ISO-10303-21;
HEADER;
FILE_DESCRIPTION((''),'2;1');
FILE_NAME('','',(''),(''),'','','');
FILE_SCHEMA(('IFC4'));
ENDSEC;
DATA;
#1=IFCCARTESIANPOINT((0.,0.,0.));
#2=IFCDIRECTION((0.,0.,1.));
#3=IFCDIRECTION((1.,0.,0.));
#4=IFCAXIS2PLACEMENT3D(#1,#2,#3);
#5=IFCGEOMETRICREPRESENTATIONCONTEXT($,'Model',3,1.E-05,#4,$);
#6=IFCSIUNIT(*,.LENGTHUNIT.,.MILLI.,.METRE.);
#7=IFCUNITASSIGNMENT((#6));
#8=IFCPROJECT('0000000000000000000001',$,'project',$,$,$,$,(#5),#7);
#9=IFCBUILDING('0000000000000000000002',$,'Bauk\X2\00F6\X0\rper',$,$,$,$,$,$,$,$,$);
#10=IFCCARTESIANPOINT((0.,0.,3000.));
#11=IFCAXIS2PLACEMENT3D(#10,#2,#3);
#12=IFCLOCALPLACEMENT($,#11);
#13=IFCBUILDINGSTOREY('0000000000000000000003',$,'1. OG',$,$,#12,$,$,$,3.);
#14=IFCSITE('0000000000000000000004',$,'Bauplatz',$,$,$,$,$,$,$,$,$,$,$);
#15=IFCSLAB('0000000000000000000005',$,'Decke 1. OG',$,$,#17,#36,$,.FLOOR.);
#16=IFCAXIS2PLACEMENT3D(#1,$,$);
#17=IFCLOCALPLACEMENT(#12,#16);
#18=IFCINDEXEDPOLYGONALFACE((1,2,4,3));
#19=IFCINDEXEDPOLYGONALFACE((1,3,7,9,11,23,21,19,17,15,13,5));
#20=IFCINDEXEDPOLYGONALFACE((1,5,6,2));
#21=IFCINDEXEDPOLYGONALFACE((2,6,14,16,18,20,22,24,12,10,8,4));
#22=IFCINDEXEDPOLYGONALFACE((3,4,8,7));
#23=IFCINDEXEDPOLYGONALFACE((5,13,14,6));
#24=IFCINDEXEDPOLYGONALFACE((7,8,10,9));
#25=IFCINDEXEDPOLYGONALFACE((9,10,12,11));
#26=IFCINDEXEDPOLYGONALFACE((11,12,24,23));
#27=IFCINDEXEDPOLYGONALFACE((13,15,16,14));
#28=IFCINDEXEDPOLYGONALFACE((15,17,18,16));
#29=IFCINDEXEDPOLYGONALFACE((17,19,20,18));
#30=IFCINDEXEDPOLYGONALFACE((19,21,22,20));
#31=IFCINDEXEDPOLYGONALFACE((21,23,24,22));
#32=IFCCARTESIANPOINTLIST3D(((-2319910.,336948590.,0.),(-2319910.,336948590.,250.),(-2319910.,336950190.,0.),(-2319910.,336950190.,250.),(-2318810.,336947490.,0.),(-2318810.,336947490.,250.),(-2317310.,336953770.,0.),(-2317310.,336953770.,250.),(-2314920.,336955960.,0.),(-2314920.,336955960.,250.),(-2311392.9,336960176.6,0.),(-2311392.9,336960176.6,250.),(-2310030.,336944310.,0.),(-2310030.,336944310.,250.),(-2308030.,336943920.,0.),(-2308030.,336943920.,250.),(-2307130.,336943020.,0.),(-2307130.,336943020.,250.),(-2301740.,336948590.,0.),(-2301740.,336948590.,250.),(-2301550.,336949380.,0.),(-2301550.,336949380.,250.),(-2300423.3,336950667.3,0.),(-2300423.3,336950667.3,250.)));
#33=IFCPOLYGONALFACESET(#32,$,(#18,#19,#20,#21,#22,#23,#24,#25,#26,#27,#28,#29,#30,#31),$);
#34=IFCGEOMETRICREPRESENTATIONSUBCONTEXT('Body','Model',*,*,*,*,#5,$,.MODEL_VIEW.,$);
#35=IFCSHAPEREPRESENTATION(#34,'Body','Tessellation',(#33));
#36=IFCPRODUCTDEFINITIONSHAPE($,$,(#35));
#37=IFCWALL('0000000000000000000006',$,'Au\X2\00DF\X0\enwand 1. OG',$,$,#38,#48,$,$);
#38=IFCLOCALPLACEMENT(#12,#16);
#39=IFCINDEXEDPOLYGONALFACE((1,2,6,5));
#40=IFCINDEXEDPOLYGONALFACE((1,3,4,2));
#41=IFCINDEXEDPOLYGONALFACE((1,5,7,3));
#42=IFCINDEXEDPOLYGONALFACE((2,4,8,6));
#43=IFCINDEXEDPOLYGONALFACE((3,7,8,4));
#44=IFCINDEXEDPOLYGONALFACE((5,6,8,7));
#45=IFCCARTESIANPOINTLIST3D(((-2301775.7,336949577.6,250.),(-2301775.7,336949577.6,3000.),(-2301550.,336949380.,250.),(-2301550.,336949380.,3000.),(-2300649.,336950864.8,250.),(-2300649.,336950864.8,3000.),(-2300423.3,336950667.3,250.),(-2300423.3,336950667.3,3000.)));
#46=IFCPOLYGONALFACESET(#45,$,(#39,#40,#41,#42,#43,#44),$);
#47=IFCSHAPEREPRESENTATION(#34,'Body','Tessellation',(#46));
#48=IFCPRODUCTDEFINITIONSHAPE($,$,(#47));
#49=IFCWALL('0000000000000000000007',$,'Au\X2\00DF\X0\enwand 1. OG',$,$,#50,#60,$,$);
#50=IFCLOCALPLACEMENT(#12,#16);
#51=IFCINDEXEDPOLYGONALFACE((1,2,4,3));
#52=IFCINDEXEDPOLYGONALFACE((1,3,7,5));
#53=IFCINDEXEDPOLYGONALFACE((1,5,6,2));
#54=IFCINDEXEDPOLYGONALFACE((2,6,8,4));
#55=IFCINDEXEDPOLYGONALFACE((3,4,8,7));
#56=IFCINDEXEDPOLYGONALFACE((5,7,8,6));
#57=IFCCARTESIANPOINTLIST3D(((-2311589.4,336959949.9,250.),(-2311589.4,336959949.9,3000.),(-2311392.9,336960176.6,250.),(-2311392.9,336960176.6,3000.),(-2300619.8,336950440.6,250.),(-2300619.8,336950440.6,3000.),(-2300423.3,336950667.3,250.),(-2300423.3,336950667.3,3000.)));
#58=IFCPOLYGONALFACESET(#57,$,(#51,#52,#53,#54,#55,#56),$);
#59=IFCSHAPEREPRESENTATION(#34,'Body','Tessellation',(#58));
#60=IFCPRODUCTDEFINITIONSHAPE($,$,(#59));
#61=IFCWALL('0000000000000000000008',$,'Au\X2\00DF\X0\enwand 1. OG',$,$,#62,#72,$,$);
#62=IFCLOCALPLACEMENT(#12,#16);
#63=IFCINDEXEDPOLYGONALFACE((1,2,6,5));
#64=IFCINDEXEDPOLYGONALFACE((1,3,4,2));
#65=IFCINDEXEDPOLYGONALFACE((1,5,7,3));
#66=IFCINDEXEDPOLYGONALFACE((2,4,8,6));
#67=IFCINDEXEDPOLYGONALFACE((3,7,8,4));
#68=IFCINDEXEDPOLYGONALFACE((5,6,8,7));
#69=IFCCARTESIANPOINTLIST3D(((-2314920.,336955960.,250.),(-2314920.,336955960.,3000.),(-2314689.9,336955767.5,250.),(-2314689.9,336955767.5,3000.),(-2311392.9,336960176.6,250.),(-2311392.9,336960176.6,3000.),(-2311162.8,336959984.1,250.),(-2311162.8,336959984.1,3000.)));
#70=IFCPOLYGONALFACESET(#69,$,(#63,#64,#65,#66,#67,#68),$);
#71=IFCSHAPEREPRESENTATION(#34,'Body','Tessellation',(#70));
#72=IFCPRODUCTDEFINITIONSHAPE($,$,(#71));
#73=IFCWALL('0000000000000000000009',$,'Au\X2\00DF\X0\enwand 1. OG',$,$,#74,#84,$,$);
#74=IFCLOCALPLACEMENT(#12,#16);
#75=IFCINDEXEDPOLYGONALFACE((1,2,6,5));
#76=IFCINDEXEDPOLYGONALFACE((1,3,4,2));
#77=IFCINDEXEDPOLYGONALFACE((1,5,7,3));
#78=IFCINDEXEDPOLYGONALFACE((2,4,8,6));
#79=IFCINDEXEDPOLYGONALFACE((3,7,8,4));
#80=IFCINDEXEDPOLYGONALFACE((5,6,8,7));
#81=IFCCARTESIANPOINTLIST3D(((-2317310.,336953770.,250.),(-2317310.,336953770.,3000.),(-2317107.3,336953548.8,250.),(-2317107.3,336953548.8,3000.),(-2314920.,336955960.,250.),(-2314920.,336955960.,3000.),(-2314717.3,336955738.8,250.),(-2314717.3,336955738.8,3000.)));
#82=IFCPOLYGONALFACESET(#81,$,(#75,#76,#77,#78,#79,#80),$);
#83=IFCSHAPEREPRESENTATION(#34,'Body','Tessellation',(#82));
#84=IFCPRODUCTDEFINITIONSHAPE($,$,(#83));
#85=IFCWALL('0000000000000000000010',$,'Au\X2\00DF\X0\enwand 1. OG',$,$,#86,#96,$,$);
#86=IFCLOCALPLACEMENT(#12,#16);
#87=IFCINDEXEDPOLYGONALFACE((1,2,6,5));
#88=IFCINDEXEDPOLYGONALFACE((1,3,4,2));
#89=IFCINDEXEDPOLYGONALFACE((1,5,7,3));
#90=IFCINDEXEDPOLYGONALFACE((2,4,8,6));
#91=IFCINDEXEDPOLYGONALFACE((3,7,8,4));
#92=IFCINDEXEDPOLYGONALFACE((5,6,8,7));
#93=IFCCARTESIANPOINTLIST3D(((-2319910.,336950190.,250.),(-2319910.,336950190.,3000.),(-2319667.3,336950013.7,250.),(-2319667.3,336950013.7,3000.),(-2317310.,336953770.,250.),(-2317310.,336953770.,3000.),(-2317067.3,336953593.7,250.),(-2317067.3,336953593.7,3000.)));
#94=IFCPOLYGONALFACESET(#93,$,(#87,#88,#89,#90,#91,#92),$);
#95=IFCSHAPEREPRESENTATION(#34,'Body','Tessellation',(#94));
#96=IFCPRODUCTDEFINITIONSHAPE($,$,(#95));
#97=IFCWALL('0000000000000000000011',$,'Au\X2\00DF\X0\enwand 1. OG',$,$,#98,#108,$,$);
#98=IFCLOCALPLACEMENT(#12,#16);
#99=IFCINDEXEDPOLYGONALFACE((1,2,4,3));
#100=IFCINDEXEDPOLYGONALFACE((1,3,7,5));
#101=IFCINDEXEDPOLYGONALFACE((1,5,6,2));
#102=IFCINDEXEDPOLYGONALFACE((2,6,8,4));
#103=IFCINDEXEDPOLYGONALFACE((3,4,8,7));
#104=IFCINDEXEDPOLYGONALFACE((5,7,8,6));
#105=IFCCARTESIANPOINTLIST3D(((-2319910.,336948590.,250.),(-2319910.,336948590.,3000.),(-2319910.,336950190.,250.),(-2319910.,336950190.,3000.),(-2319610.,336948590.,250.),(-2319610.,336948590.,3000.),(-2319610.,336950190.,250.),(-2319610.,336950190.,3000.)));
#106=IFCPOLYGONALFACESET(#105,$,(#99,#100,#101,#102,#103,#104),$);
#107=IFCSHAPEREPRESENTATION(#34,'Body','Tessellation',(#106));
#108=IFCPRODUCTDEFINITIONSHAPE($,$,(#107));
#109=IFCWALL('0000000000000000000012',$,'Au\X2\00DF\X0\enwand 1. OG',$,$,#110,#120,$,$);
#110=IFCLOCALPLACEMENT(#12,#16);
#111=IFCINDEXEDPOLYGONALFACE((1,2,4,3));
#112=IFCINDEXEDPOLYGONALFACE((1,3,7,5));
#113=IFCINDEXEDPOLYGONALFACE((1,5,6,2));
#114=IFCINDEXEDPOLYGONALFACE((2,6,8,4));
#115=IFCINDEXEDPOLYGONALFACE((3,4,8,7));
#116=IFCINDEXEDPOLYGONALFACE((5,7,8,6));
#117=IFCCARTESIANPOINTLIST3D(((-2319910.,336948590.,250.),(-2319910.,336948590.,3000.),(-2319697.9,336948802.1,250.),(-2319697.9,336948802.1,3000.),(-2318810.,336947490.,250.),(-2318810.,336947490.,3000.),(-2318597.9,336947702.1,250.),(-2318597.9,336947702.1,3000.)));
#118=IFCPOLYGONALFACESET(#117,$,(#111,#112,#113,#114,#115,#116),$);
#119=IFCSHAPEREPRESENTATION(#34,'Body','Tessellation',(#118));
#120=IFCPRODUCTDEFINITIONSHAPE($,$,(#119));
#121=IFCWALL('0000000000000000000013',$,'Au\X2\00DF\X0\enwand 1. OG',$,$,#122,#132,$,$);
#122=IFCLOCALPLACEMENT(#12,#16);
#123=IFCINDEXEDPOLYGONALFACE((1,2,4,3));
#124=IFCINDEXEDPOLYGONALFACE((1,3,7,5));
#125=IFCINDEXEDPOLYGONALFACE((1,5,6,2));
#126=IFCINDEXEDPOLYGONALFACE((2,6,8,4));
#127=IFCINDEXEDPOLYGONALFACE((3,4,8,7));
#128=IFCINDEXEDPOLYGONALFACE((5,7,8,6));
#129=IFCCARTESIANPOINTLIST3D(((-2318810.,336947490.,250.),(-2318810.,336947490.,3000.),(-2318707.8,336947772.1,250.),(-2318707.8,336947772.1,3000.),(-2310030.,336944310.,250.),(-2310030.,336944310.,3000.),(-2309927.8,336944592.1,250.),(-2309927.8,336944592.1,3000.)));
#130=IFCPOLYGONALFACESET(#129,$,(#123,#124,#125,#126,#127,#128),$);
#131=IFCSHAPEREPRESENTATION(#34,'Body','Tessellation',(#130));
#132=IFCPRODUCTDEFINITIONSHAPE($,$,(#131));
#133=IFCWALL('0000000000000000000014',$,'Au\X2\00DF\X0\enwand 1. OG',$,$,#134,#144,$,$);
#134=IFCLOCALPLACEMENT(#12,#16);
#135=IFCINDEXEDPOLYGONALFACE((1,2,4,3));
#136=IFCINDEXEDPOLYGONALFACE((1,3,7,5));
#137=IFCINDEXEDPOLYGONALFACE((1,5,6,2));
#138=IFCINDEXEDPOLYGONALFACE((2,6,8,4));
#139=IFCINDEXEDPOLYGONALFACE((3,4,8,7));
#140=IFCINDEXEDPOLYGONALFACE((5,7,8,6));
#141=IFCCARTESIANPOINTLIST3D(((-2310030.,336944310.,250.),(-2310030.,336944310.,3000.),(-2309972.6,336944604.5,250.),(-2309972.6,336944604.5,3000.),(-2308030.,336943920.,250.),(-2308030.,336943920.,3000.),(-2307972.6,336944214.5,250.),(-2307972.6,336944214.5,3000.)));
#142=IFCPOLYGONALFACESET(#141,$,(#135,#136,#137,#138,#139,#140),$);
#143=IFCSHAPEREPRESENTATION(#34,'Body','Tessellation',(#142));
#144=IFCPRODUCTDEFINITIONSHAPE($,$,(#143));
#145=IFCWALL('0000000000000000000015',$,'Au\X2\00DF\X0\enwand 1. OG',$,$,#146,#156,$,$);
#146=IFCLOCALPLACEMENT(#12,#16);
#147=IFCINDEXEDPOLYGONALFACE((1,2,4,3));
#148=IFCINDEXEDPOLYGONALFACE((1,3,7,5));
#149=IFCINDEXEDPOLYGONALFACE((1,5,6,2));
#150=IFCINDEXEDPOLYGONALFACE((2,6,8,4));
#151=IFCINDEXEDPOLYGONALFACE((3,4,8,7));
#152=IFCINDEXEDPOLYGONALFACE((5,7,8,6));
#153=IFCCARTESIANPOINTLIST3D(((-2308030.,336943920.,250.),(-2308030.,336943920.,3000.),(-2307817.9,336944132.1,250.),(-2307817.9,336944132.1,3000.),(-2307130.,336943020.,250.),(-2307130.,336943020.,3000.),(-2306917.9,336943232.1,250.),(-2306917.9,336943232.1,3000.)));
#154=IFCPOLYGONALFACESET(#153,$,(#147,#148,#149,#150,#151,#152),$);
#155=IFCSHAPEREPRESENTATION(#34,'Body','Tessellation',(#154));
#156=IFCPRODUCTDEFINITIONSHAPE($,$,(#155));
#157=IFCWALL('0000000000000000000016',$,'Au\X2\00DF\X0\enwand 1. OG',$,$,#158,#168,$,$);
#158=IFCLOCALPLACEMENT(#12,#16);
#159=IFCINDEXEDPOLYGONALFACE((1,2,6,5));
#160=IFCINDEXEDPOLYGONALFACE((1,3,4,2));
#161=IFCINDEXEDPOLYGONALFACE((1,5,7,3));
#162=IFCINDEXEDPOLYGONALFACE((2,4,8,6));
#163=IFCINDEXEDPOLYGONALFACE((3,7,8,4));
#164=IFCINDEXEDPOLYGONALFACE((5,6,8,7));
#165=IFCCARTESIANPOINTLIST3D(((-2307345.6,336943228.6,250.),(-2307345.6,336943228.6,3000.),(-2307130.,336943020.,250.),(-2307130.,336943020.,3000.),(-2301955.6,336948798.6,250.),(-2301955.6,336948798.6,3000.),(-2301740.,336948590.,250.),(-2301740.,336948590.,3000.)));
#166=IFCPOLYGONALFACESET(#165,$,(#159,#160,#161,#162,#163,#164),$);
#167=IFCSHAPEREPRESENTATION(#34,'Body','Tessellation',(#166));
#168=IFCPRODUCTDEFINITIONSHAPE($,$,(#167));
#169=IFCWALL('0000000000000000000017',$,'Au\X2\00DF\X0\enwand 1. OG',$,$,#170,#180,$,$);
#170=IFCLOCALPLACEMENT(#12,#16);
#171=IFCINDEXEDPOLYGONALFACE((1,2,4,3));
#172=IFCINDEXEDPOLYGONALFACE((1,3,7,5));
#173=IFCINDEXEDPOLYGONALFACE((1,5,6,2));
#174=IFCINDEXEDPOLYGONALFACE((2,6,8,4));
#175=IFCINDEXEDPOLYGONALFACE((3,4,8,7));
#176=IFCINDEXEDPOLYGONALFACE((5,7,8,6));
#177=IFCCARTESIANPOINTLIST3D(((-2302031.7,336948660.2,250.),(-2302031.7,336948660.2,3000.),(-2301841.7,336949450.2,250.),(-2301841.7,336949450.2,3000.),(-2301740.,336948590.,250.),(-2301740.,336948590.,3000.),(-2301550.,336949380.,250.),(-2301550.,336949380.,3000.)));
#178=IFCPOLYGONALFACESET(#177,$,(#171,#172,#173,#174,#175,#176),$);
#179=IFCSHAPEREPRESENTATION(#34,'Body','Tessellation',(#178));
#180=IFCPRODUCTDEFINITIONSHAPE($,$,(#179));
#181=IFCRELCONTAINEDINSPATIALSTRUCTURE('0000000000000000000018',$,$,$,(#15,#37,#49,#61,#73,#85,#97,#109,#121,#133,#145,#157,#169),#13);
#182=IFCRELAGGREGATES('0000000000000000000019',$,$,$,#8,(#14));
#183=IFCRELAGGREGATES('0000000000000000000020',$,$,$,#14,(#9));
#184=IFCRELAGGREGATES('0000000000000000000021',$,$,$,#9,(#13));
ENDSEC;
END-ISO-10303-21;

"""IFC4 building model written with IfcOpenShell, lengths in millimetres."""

from ifc_helpers import new_model, si_unit, frame, origin_with_axes, place, context, subcontext, project, spatial, indexed_curve, outline, extrude, element, save


model = new_model("IFC4")

# Units and contexts
model_context = context("Model", 3, precision=1e-05, world=origin_with_axes())
body_context = subcontext(model_context, "Body", "Model", "MODEL_VIEW")
ifc_project = project(units=[si_unit("LENGTHUNIT", "METRE", prefix="MILLI")], contexts=[model_context])

# Site, building, storey
site = spatial("IfcSite", under=ifc_project, Name="Bauplatz")
building = spatial("IfcBuilding", under=site, Name="Baukörper")
storey_placement = place(None, frame((0.0, 0.0, 3000.0), z_axis=(0.0, 0.0, 1.0), x_axis=(1.0, 0.0, 0.0)))
storey = spatial("IfcBuildingStorey", under=building, at=storey_placement, Name="1. OG", Elevation=3.0)

# Slab
slab_placement = place(storey_placement, origin_with_axes())
element("IfcSlab", 1, at=slab_placement, inside=storey, Name="Decke 1. OG", PredefinedType="FLOOR", context=body_context, shape_type="SweptSolid", body=[
    extrude(outline(indexed_curve([(-2301550.0, 336949380.0), (-2301740.0, 336948590.0), (-2307130.0, 336943020.0), (-2308030.0, 336943920.0), (-2310030.0, 336944310.0), (-2318810.0, 336947490.0), (-2319910.0, 336948590.0), (-2319910.0, 336950190.0), (-2317310.0, 336953770.0), (-2314920.0, 336955960.0), (-2311392.9, 336960176.6), (-2300423.3, 336950667.3)])), None, (0.0, 0.0, 1.0), 250.0),
])

# Walls
wall_1_placement = place(storey_placement, frame((-2301550.0, 336949380.0, 250.0), z_axis=(0.0, 0.0, 1.0), x_axis=(0.658621, 0.752475, 0.0)))
element("IfcWall", 2, at=wall_1_placement, inside=storey, Name="Außenwand 1. OG", context=body_context, shape_type="SweptSolid", body=[
    extrude(outline(indexed_curve([(0.0, 0.0), (0.0, 300.0), (1710.7, 300.0), (1710.7, 0.0), (0.0, 0.0)], self_intersect=False)), origin_with_axes(), (0.0, 0.0, 1.0), 2750.0),
])
wall_2_placement = place(storey_placement, frame((-2300423.3, 336950667.3, 250.0), z_axis=(0.0, 0.0, 1.0), x_axis=(-0.75561, 0.655022, 0.0)))
element("IfcWall", 3, at=wall_2_placement, inside=storey, Name="Außenwand 1. OG", context=body_context, shape_type="SweptSolid", body=[
    extrude(outline(indexed_curve([(0.0, 0.0), (0.0, 300.0), (14517.6, 300.0), (14517.6, 0.0), (0.0, 0.0)], self_intersect=False)), origin_with_axes(), (0.0, 0.0, 1.0), 2750.0),
])
wall_3_placement = place(storey_placement, frame((-2311392.9, 336960176.6, 250.0), z_axis=(0.0, 0.0, 1.0), x_axis=(-0.641607, -0.767034, 0.0)))
element("IfcWall", 4, at=wall_3_placement, inside=storey, Name="Außenwand 1. OG", context=body_context, shape_type="SweptSolid", body=[
    extrude(outline(indexed_curve([(0.0, 0.0), (0.0, 300.0), (5497.3, 300.0), (5497.3, 0.0), (0.0, 0.0)], self_intersect=False)), origin_with_axes(), (0.0, 0.0, 1.0), 2750.0),
])
wall_4_placement = place(storey_placement, frame((-2314920.0, 336955960.0, 250.0), z_axis=(0.0, 0.0, 1.0), x_axis=(-0.737282, -0.675585, 0.0)))
element("IfcWall", 5, at=wall_4_placement, inside=storey, Name="Außenwand 1. OG", context=body_context, shape_type="SweptSolid", body=[
    extrude(outline(indexed_curve([(0.0, 0.0), (0.0, 300.0), (3241.6, 300.0), (3241.6, 0.0), (0.0, 0.0)], self_intersect=False)), origin_with_axes(), (0.0, 0.0, 1.0), 2750.0),
])
wall_5_placement = place(storey_placement, frame((-2317310.0, 336953770.0, 250.0), z_axis=(0.0, 0.0, 1.0), x_axis=(-0.587634, -0.809127, 0.0)))
element("IfcWall", 6, at=wall_5_placement, inside=storey, Name="Außenwand 1. OG", context=body_context, shape_type="SweptSolid", body=[
    extrude(outline(indexed_curve([(0.0, 0.0), (0.0, 300.0), (4424.5, 300.0), (4424.5, 0.0), (0.0, 0.0)], self_intersect=False)), origin_with_axes(), (0.0, 0.0, 1.0), 2750.0),
])
wall_6_placement = place(storey_placement, frame((-2319910.0, 336950190.0, 250.0), z_axis=(0.0, 0.0, 1.0), x_axis=(0.0, -1.0, 0.0)))
element("IfcWall", 7, at=wall_6_placement, inside=storey, Name="Außenwand 1. OG", context=body_context, shape_type="SweptSolid", body=[
    extrude(outline(indexed_curve([(0.0, 0.0), (0.0, 300.0), (1600.0, 300.0), (1600.0, 0.0), (0.0, 0.0)], self_intersect=False)), origin_with_axes(), (0.0, 0.0, 1.0), 2750.0),
])
wall_7_placement = place(storey_placement, frame((-2319910.0, 336948590.0, 250.0), z_axis=(0.0, 0.0, 1.0), x_axis=(0.707107, -0.707107, 0.0)))
element("IfcWall", 8, at=wall_7_placement, inside=storey, Name="Außenwand 1. OG", context=body_context, shape_type="SweptSolid", body=[
    extrude(outline(indexed_curve([(0.0, 0.0), (0.0, 300.0), (1555.6, 300.0), (1555.6, 0.0), (0.0, 0.0)], self_intersect=False)), origin_with_axes(), (0.0, 0.0, 1.0), 2750.0),
])
wall_8_placement = place(storey_placement, frame((-2318810.0, 336947490.0, 250.0), z_axis=(0.0, 0.0, 1.0), x_axis=(0.94023, -0.340539, 0.0)))
element("IfcWall", 9, at=wall_8_placement, inside=storey, Name="Außenwand 1. OG", context=body_context, shape_type="SweptSolid", body=[
    extrude(outline(indexed_curve([(0.0, 0.0), (0.0, 300.0), (9338.1, 300.0), (9338.1, 0.0), (0.0, 0.0)], self_intersect=False)), origin_with_axes(), (0.0, 0.0, 1.0), 2750.0),
])
wall_9_placement = place(storey_placement, frame((-2310030.0, 336944310.0, 250.0), z_axis=(0.0, 0.0, 1.0), x_axis=(0.981513, -0.191395, 0.0)))
element("IfcWall", 10, at=wall_9_placement, inside=storey, Name="Außenwand 1. OG", context=body_context, shape_type="SweptSolid", body=[
    extrude(outline(indexed_curve([(0.0, 0.0), (0.0, 300.0), (2037.7, 300.0), (2037.7, 0.0), (0.0, 0.0)], self_intersect=False)), origin_with_axes(), (0.0, 0.0, 1.0), 2750.0),
])
wall_10_placement = place(storey_placement, frame((-2308030.0, 336943920.0, 250.0), z_axis=(0.0, 0.0, 1.0), x_axis=(0.707107, -0.707107, 0.0)))
element("IfcWall", 11, at=wall_10_placement, inside=storey, Name="Außenwand 1. OG", context=body_context, shape_type="SweptSolid", body=[
    extrude(outline(indexed_curve([(0.0, 0.0), (0.0, 300.0), (1272.8, 300.0), (1272.8, 0.0), (0.0, 0.0)], self_intersect=False)), origin_with_axes(), (0.0, 0.0, 1.0), 2750.0),
])
wall_11_placement = place(storey_placement, frame((-2307130.0, 336943020.0, 250.0), z_axis=(0.0, 0.0, 1.0), x_axis=(0.6954, 0.718623, 0.0)))
element("IfcWall", 12, at=wall_11_placement, inside=storey, Name="Außenwand 1. OG", context=body_context, shape_type="SweptSolid", body=[
    extrude(outline(indexed_curve([(0.0, 0.0), (0.0, 300.0), (7750.9, 300.0), (7750.9, 0.0), (0.0, 0.0)], self_intersect=False)), origin_with_axes(), (0.0, 0.0, 1.0), 2750.0),
])
wall_12_placement = place(storey_placement, frame((-2301740.0, 336948590.0, 250.0), z_axis=(0.0, 0.0, 1.0), x_axis=(0.233838, 0.972275, 0.0)))
element("IfcWall", 13, at=wall_12_placement, inside=storey, Name="Außenwand 1. OG", context=body_context, shape_type="SweptSolid", body=[
    extrude(outline(indexed_curve([(0.0, 0.0), (0.0, 300.0), (812.5, 300.0), (812.5, 0.0), (0.0, 0.0)], self_intersect=False)), origin_with_axes(), (0.0, 0.0, 1.0), 2750.0),
])

save(model, "model.ifc")
